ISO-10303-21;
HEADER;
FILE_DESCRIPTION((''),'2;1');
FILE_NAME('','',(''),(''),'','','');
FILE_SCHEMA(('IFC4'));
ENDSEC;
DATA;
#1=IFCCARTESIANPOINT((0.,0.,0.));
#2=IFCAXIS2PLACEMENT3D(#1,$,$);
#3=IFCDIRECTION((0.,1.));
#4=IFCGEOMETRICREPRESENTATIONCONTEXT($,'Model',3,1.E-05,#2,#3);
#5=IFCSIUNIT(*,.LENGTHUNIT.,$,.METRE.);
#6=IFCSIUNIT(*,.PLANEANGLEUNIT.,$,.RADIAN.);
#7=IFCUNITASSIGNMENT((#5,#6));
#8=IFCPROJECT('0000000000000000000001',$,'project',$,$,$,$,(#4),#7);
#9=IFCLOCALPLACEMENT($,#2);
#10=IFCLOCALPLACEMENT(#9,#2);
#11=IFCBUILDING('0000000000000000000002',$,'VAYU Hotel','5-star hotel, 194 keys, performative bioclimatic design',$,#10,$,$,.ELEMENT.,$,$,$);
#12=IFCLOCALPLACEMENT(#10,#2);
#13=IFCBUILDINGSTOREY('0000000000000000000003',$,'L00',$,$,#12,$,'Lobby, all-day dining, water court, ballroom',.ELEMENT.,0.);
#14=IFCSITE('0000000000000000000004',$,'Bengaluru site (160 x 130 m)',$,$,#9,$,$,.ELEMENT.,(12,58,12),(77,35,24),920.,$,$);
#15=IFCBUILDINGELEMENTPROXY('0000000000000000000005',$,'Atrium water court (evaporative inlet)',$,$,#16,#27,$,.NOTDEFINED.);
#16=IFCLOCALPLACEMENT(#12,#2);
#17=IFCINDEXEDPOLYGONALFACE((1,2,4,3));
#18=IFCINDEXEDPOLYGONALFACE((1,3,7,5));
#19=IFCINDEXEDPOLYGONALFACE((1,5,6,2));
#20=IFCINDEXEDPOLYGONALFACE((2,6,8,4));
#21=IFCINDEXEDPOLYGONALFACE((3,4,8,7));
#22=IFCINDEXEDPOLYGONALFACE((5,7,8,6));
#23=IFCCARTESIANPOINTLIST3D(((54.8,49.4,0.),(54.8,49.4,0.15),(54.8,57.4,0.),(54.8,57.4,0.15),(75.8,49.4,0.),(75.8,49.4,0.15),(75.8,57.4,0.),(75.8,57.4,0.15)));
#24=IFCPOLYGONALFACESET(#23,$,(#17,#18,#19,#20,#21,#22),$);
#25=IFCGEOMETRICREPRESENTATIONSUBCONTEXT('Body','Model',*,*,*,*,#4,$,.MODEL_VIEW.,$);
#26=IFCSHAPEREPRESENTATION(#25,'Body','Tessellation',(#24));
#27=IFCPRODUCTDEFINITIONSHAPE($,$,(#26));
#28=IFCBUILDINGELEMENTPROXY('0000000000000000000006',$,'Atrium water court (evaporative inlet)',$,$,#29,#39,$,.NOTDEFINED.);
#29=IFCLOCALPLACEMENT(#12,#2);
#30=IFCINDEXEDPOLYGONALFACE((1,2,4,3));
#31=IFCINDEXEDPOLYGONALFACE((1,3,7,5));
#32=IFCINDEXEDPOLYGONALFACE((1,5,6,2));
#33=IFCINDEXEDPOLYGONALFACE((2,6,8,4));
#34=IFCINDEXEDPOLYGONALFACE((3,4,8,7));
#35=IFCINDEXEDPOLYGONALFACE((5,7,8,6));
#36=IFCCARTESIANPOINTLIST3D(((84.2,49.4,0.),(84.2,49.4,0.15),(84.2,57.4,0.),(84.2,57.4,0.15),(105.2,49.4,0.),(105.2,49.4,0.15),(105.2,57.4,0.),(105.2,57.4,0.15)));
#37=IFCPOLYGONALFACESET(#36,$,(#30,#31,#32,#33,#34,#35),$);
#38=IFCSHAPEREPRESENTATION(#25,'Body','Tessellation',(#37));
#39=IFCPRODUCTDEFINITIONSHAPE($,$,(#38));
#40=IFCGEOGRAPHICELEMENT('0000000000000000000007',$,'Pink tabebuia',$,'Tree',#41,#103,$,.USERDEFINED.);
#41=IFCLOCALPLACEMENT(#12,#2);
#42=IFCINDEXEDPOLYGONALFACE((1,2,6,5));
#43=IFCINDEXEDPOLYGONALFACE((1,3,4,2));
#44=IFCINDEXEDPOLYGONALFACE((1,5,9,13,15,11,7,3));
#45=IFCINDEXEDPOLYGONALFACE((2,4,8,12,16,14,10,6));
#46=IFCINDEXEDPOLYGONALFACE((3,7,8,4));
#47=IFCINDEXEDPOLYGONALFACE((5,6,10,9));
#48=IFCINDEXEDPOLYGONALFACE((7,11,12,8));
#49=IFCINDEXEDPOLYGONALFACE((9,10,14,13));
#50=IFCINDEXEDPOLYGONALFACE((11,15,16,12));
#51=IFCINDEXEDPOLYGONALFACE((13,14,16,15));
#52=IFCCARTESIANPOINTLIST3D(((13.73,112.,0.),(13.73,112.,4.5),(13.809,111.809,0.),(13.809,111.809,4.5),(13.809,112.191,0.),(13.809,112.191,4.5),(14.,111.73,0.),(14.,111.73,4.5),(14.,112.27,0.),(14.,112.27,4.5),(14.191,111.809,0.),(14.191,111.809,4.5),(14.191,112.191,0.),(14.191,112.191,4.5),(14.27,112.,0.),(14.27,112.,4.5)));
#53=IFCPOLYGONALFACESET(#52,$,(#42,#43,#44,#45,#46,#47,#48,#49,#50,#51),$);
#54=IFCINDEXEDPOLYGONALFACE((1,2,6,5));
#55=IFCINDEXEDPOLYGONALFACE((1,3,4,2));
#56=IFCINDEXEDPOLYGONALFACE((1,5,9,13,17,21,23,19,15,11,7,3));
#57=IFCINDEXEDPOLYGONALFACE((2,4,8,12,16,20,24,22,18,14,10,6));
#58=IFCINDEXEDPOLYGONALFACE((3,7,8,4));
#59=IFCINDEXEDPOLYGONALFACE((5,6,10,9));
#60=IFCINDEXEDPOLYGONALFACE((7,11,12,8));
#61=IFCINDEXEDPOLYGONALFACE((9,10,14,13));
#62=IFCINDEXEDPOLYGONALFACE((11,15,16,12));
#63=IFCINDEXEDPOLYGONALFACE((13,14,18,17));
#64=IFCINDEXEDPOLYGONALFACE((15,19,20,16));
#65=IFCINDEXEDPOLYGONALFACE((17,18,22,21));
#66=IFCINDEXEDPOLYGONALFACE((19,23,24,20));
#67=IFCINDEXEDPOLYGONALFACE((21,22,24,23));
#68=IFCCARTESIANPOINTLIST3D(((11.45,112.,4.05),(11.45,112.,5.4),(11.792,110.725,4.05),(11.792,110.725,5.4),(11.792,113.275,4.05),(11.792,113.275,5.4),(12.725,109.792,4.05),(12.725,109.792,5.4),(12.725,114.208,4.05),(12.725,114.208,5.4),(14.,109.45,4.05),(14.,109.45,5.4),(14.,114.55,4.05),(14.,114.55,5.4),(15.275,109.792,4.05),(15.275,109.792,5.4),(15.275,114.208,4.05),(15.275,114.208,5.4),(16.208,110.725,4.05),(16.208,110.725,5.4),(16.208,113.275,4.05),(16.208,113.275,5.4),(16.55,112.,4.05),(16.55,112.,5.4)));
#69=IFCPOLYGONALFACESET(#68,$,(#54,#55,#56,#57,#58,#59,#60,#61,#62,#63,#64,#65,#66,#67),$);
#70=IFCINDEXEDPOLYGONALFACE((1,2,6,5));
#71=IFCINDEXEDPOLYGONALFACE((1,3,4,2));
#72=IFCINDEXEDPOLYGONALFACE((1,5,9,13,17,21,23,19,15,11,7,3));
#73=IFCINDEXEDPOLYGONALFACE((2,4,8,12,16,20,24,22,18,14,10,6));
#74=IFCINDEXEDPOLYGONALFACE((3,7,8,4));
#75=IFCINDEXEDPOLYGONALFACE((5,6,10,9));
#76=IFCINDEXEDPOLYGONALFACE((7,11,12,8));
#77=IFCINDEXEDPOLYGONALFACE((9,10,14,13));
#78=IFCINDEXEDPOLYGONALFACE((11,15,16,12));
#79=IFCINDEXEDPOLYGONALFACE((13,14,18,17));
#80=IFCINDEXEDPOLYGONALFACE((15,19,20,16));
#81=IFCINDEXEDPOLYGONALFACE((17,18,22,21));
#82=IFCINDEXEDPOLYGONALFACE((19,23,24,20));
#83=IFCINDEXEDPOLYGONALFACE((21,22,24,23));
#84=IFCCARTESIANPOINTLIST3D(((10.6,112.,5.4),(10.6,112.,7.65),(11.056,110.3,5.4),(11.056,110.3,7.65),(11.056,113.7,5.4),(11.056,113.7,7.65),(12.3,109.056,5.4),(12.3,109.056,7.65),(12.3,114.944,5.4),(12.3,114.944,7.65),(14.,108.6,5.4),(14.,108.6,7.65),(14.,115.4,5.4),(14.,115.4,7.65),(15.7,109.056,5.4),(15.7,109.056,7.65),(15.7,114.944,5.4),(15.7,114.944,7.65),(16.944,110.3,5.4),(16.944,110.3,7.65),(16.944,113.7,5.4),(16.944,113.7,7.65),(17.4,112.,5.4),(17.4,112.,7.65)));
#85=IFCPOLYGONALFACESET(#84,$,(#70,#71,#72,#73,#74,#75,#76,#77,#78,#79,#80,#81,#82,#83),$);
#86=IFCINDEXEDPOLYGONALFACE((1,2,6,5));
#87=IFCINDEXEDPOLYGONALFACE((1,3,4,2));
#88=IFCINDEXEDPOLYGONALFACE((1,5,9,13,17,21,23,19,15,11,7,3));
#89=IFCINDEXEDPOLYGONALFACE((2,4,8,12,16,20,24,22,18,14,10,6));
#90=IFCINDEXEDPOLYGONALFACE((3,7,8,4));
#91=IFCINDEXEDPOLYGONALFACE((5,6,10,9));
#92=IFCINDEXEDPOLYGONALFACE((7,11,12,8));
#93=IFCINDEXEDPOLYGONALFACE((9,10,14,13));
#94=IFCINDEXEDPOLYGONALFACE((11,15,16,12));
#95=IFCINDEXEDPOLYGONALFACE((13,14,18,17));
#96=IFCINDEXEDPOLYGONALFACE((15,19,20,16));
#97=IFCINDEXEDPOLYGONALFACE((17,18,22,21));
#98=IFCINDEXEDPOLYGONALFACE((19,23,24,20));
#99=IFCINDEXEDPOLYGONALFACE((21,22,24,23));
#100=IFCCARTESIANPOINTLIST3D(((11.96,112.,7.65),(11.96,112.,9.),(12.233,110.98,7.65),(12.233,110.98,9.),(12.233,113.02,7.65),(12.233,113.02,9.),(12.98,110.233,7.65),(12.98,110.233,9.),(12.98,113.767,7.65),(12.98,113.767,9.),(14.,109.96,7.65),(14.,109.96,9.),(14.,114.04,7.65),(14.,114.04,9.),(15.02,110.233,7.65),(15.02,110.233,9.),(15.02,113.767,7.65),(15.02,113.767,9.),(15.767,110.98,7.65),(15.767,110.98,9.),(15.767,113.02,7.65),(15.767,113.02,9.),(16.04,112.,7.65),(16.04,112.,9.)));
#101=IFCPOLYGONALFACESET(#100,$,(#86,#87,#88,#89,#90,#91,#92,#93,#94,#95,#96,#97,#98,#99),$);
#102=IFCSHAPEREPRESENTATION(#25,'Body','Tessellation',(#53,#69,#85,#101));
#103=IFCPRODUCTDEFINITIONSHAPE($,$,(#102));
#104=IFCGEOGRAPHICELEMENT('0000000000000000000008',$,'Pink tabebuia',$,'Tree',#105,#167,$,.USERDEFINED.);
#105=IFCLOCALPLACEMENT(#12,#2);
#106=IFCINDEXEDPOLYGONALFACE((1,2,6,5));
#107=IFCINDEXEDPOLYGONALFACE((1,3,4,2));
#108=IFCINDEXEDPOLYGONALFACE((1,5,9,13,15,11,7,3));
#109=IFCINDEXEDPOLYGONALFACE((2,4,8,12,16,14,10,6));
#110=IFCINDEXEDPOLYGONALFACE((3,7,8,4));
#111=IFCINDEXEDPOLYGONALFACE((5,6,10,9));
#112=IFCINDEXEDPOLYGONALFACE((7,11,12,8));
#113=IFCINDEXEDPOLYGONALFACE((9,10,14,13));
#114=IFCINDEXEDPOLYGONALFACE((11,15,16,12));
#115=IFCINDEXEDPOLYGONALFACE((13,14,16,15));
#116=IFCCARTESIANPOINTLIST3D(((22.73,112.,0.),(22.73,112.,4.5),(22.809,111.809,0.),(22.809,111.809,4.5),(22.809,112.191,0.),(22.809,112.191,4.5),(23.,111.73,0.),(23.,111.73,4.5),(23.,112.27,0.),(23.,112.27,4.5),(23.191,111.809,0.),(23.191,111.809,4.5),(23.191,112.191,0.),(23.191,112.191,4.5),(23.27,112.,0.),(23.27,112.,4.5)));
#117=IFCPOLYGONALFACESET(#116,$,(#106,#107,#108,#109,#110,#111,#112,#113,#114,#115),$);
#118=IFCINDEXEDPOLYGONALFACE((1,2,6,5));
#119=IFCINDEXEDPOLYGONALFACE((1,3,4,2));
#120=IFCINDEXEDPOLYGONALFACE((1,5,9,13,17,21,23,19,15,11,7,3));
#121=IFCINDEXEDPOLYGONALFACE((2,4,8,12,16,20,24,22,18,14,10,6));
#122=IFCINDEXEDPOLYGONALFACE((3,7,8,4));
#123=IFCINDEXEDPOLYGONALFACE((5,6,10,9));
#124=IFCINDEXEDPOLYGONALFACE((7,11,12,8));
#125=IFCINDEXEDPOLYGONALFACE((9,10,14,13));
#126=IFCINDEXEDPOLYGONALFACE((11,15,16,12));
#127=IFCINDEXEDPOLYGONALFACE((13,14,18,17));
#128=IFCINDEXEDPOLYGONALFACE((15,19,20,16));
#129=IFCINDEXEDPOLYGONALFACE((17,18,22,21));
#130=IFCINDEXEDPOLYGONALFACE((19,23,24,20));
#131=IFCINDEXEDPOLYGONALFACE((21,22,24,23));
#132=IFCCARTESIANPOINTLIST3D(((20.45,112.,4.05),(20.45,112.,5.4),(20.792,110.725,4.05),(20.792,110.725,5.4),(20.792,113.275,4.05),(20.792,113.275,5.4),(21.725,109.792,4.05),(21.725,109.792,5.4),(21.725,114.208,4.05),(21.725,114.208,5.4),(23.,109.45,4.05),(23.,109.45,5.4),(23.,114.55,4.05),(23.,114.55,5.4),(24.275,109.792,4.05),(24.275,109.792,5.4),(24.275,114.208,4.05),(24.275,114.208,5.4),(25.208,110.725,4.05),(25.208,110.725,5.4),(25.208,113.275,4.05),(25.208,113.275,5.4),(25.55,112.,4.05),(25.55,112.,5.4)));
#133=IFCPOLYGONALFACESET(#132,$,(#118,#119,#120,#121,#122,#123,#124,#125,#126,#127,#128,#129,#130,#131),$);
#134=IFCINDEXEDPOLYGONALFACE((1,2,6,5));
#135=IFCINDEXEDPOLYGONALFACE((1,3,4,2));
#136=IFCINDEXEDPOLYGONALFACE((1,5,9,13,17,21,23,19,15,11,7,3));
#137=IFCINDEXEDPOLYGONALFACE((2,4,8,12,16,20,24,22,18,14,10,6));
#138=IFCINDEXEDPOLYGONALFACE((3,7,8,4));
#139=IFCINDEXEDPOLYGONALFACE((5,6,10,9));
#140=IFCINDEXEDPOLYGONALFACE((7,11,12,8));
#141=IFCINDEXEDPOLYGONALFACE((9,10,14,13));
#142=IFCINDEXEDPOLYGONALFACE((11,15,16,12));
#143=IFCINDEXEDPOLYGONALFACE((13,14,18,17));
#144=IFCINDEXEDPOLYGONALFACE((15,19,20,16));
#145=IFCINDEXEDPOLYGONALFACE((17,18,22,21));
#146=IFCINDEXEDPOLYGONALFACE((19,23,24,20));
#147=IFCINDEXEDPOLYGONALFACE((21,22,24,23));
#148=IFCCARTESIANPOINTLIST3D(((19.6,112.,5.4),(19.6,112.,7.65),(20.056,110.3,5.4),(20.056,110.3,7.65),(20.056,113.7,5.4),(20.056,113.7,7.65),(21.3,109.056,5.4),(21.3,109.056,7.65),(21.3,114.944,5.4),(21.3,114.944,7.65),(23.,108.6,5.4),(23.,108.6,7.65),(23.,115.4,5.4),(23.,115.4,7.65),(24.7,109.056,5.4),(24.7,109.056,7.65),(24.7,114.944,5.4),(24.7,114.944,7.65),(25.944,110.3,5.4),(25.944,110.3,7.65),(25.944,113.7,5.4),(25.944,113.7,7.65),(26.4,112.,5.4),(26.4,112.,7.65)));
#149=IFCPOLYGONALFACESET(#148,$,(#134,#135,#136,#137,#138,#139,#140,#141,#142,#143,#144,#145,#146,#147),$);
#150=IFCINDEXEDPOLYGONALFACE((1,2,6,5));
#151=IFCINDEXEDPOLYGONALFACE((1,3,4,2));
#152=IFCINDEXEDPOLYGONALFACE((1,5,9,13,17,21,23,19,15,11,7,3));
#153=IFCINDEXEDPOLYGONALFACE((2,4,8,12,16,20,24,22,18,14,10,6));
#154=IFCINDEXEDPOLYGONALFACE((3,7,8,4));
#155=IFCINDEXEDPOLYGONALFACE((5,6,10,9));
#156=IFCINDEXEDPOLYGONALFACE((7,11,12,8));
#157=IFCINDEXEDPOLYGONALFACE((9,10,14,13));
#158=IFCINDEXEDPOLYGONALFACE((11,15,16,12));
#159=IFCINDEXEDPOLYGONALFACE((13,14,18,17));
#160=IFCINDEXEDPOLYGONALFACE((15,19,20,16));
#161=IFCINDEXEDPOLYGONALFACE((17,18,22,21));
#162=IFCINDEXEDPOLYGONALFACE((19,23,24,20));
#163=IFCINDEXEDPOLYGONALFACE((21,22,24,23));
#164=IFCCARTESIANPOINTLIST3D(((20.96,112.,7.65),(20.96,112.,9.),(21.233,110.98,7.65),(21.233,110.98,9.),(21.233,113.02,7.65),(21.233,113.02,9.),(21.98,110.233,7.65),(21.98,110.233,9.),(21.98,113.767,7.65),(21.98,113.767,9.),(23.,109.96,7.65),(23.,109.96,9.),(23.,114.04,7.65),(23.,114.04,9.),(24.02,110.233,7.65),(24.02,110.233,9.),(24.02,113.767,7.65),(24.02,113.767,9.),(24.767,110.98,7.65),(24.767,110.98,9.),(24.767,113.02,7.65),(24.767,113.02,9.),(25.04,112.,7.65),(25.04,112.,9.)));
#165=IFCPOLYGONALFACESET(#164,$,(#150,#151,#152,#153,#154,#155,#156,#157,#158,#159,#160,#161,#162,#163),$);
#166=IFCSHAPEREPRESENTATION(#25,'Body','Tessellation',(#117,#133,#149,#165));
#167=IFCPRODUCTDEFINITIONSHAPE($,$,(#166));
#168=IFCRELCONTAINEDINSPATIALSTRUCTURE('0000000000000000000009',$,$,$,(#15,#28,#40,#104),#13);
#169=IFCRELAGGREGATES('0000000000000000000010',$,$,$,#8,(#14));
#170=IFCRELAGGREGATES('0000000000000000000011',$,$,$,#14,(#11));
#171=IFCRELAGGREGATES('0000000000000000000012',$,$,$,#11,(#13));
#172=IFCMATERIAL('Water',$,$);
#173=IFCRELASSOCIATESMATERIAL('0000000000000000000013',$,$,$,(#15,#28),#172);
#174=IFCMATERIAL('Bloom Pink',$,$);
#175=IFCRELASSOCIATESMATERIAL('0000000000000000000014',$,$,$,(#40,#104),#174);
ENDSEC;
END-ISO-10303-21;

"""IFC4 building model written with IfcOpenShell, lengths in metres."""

from ifc_helpers import new_model, si_unit, direction, frame, origin, place, context, subcontext, project, spatial, polyline, outline, extrude, material, element, save


model = new_model("IFC4")

# Units and contexts
model_context = context("Model", 3, precision=1e-05, world=origin(), true_north=direction((0.0, 1.0)))
body_context = subcontext(model_context, "Body", "Model", "MODEL_VIEW")
ifc_project = project(units=[si_unit("LENGTHUNIT", "METRE"), si_unit("PLANEANGLEUNIT", "RADIAN")], contexts=[model_context])

# Site, building, storey
site_placement = place(None, origin())
site = spatial("IfcSite", under=ifc_project, at=site_placement, Name="Bengaluru site (160 x 130 m)", CompositionType="ELEMENT", RefLatitude=(12, 58, 12), RefLongitude=(77, 35, 24), RefElevation=920.0)
building_placement = place(site_placement, origin())
building = spatial("IfcBuilding", under=site, at=building_placement, Name="VAYU Hotel", Description="5-star hotel, 194 keys, performative bioclimatic design", CompositionType="ELEMENT")
storey_placement = place(building_placement, origin())
storey = spatial("IfcBuildingStorey", under=building, at=storey_placement, Name="L00", LongName="Lobby, all-day dining, water court, ballroom", CompositionType="ELEMENT", Elevation=0.0)

# Building element proxies
ifc_material_1 = material(Name="Water")
proxy_1_placement = place(storey_placement, origin())
element("IfcBuildingElementProxy", 1, at=proxy_1_placement, inside=storey, material=ifc_material_1, Name="Atrium water court (evaporative inlet)", PredefinedType="NOTDEFINED", context=body_context, shape_type="SweptSolid", body=[
    extrude(outline(polyline([(54.8, 49.4), (75.8, 49.4), (75.8, 57.4), (54.8, 57.4), (54.8, 49.4)])), origin(), (0.0, 0.0, 1.0), 0.15),
])
proxy_2_placement = place(storey_placement, origin())
element("IfcBuildingElementProxy", 2, at=proxy_2_placement, inside=storey, material=ifc_material_1, Name="Atrium water court (evaporative inlet)", PredefinedType="NOTDEFINED", context=body_context, shape_type="SweptSolid", body=[
    extrude(outline(polyline([(84.2, 49.4), (105.2, 49.4), (105.2, 57.4), (84.2, 57.4), (84.2, 49.4)])), origin(), (0.0, 0.0, 1.0), 0.15),
])

# Geographic elements
ifc_material_2 = material(Name="Bloom Pink")
geographic_element_1_placement = place(storey_placement, origin())
element("IfcGeographicElement", 3, at=geographic_element_1_placement, inside=storey, material=ifc_material_2, Name="Pink tabebuia", ObjectType="Tree", PredefinedType="USERDEFINED", context=body_context, shape_type="SweptSolid", body=[
    extrude(outline(polyline([(14.27, 112.0), (14.191, 112.191), (14.0, 112.27), (13.809, 112.191), (13.73, 112.0), (13.809, 111.809), (14.0, 111.73), (14.191, 111.809), (14.27, 112.0)])), origin(), (0.0, 0.0, 1.0), 4.5),
    extrude(outline(polyline([(16.55, 112.0), (16.208, 113.275), (15.275, 114.208), (14.0, 114.55), (12.725, 114.208), (11.792, 113.275), (11.45, 112.0), (11.792, 110.725), (12.725, 109.792), (14.0, 109.45), (15.275, 109.792), (16.208, 110.725), (16.55, 112.0)])), frame((0.0, 0.0, 4.05)), (0.0, 0.0, 1.0), 1.35),
    extrude(outline(polyline([(17.4, 112.0), (16.944, 113.7), (15.7, 114.944), (14.0, 115.4), (12.3, 114.944), (11.056, 113.7), (10.6, 112.0), (11.056, 110.3), (12.3, 109.056), (14.0, 108.6), (15.7, 109.056), (16.944, 110.3), (17.4, 112.0)])), frame((0.0, 0.0, 5.4)), (0.0, 0.0, 1.0), 2.25),
    extrude(outline(polyline([(16.04, 112.0), (15.767, 113.02), (15.02, 113.767), (14.0, 114.04), (12.98, 113.767), (12.233, 113.02), (11.96, 112.0), (12.233, 110.98), (12.98, 110.233), (14.0, 109.96), (15.02, 110.233), (15.767, 110.98), (16.04, 112.0)])), frame((0.0, 0.0, 7.65)), (0.0, 0.0, 1.0), 1.35),
])
geographic_element_2_placement = place(storey_placement, origin())
element("IfcGeographicElement", 4, at=geographic_element_2_placement, inside=storey, material=ifc_material_2, Name="Pink tabebuia", ObjectType="Tree", PredefinedType="USERDEFINED", context=body_context, shape_type="SweptSolid", body=[
    extrude(outline(polyline([(23.27, 112.0), (23.191, 112.191), (23.0, 112.27), (22.809, 112.191), (22.73, 112.0), (22.809, 111.809), (23.0, 111.73), (23.191, 111.809), (23.27, 112.0)])), origin(), (0.0, 0.0, 1.0), 4.5),
    extrude(outline(polyline([(25.55, 112.0), (25.208, 113.275), (24.275, 114.208), (23.0, 114.55), (21.725, 114.208), (20.792, 113.275), (20.45, 112.0), (20.792, 110.725), (21.725, 109.792), (23.0, 109.45), (24.275, 109.792), (25.208, 110.725), (25.55, 112.0)])), frame((0.0, 0.0, 4.05)), (0.0, 0.0, 1.0), 1.35),
    extrude(outline(polyline([(26.4, 112.0), (25.944, 113.7), (24.7, 114.944), (23.0, 115.4), (21.3, 114.944), (20.056, 113.7), (19.6, 112.0), (20.056, 110.3), (21.3, 109.056), (23.0, 108.6), (24.7, 109.056), (25.944, 110.3), (26.4, 112.0)])), frame((0.0, 0.0, 5.4)), (0.0, 0.0, 1.0), 2.25),
    extrude(outline(polyline([(25.04, 112.0), (24.767, 113.02), (24.02, 113.767), (23.0, 114.04), (21.98, 113.767), (21.233, 113.02), (20.96, 112.0), (21.233, 110.98), (21.98, 110.233), (23.0, 109.96), (24.02, 110.233), (24.767, 110.98), (25.04, 112.0)])), frame((0.0, 0.0, 7.65)), (0.0, 0.0, 1.0), 1.35),
])

save(model, "model.ifc")
